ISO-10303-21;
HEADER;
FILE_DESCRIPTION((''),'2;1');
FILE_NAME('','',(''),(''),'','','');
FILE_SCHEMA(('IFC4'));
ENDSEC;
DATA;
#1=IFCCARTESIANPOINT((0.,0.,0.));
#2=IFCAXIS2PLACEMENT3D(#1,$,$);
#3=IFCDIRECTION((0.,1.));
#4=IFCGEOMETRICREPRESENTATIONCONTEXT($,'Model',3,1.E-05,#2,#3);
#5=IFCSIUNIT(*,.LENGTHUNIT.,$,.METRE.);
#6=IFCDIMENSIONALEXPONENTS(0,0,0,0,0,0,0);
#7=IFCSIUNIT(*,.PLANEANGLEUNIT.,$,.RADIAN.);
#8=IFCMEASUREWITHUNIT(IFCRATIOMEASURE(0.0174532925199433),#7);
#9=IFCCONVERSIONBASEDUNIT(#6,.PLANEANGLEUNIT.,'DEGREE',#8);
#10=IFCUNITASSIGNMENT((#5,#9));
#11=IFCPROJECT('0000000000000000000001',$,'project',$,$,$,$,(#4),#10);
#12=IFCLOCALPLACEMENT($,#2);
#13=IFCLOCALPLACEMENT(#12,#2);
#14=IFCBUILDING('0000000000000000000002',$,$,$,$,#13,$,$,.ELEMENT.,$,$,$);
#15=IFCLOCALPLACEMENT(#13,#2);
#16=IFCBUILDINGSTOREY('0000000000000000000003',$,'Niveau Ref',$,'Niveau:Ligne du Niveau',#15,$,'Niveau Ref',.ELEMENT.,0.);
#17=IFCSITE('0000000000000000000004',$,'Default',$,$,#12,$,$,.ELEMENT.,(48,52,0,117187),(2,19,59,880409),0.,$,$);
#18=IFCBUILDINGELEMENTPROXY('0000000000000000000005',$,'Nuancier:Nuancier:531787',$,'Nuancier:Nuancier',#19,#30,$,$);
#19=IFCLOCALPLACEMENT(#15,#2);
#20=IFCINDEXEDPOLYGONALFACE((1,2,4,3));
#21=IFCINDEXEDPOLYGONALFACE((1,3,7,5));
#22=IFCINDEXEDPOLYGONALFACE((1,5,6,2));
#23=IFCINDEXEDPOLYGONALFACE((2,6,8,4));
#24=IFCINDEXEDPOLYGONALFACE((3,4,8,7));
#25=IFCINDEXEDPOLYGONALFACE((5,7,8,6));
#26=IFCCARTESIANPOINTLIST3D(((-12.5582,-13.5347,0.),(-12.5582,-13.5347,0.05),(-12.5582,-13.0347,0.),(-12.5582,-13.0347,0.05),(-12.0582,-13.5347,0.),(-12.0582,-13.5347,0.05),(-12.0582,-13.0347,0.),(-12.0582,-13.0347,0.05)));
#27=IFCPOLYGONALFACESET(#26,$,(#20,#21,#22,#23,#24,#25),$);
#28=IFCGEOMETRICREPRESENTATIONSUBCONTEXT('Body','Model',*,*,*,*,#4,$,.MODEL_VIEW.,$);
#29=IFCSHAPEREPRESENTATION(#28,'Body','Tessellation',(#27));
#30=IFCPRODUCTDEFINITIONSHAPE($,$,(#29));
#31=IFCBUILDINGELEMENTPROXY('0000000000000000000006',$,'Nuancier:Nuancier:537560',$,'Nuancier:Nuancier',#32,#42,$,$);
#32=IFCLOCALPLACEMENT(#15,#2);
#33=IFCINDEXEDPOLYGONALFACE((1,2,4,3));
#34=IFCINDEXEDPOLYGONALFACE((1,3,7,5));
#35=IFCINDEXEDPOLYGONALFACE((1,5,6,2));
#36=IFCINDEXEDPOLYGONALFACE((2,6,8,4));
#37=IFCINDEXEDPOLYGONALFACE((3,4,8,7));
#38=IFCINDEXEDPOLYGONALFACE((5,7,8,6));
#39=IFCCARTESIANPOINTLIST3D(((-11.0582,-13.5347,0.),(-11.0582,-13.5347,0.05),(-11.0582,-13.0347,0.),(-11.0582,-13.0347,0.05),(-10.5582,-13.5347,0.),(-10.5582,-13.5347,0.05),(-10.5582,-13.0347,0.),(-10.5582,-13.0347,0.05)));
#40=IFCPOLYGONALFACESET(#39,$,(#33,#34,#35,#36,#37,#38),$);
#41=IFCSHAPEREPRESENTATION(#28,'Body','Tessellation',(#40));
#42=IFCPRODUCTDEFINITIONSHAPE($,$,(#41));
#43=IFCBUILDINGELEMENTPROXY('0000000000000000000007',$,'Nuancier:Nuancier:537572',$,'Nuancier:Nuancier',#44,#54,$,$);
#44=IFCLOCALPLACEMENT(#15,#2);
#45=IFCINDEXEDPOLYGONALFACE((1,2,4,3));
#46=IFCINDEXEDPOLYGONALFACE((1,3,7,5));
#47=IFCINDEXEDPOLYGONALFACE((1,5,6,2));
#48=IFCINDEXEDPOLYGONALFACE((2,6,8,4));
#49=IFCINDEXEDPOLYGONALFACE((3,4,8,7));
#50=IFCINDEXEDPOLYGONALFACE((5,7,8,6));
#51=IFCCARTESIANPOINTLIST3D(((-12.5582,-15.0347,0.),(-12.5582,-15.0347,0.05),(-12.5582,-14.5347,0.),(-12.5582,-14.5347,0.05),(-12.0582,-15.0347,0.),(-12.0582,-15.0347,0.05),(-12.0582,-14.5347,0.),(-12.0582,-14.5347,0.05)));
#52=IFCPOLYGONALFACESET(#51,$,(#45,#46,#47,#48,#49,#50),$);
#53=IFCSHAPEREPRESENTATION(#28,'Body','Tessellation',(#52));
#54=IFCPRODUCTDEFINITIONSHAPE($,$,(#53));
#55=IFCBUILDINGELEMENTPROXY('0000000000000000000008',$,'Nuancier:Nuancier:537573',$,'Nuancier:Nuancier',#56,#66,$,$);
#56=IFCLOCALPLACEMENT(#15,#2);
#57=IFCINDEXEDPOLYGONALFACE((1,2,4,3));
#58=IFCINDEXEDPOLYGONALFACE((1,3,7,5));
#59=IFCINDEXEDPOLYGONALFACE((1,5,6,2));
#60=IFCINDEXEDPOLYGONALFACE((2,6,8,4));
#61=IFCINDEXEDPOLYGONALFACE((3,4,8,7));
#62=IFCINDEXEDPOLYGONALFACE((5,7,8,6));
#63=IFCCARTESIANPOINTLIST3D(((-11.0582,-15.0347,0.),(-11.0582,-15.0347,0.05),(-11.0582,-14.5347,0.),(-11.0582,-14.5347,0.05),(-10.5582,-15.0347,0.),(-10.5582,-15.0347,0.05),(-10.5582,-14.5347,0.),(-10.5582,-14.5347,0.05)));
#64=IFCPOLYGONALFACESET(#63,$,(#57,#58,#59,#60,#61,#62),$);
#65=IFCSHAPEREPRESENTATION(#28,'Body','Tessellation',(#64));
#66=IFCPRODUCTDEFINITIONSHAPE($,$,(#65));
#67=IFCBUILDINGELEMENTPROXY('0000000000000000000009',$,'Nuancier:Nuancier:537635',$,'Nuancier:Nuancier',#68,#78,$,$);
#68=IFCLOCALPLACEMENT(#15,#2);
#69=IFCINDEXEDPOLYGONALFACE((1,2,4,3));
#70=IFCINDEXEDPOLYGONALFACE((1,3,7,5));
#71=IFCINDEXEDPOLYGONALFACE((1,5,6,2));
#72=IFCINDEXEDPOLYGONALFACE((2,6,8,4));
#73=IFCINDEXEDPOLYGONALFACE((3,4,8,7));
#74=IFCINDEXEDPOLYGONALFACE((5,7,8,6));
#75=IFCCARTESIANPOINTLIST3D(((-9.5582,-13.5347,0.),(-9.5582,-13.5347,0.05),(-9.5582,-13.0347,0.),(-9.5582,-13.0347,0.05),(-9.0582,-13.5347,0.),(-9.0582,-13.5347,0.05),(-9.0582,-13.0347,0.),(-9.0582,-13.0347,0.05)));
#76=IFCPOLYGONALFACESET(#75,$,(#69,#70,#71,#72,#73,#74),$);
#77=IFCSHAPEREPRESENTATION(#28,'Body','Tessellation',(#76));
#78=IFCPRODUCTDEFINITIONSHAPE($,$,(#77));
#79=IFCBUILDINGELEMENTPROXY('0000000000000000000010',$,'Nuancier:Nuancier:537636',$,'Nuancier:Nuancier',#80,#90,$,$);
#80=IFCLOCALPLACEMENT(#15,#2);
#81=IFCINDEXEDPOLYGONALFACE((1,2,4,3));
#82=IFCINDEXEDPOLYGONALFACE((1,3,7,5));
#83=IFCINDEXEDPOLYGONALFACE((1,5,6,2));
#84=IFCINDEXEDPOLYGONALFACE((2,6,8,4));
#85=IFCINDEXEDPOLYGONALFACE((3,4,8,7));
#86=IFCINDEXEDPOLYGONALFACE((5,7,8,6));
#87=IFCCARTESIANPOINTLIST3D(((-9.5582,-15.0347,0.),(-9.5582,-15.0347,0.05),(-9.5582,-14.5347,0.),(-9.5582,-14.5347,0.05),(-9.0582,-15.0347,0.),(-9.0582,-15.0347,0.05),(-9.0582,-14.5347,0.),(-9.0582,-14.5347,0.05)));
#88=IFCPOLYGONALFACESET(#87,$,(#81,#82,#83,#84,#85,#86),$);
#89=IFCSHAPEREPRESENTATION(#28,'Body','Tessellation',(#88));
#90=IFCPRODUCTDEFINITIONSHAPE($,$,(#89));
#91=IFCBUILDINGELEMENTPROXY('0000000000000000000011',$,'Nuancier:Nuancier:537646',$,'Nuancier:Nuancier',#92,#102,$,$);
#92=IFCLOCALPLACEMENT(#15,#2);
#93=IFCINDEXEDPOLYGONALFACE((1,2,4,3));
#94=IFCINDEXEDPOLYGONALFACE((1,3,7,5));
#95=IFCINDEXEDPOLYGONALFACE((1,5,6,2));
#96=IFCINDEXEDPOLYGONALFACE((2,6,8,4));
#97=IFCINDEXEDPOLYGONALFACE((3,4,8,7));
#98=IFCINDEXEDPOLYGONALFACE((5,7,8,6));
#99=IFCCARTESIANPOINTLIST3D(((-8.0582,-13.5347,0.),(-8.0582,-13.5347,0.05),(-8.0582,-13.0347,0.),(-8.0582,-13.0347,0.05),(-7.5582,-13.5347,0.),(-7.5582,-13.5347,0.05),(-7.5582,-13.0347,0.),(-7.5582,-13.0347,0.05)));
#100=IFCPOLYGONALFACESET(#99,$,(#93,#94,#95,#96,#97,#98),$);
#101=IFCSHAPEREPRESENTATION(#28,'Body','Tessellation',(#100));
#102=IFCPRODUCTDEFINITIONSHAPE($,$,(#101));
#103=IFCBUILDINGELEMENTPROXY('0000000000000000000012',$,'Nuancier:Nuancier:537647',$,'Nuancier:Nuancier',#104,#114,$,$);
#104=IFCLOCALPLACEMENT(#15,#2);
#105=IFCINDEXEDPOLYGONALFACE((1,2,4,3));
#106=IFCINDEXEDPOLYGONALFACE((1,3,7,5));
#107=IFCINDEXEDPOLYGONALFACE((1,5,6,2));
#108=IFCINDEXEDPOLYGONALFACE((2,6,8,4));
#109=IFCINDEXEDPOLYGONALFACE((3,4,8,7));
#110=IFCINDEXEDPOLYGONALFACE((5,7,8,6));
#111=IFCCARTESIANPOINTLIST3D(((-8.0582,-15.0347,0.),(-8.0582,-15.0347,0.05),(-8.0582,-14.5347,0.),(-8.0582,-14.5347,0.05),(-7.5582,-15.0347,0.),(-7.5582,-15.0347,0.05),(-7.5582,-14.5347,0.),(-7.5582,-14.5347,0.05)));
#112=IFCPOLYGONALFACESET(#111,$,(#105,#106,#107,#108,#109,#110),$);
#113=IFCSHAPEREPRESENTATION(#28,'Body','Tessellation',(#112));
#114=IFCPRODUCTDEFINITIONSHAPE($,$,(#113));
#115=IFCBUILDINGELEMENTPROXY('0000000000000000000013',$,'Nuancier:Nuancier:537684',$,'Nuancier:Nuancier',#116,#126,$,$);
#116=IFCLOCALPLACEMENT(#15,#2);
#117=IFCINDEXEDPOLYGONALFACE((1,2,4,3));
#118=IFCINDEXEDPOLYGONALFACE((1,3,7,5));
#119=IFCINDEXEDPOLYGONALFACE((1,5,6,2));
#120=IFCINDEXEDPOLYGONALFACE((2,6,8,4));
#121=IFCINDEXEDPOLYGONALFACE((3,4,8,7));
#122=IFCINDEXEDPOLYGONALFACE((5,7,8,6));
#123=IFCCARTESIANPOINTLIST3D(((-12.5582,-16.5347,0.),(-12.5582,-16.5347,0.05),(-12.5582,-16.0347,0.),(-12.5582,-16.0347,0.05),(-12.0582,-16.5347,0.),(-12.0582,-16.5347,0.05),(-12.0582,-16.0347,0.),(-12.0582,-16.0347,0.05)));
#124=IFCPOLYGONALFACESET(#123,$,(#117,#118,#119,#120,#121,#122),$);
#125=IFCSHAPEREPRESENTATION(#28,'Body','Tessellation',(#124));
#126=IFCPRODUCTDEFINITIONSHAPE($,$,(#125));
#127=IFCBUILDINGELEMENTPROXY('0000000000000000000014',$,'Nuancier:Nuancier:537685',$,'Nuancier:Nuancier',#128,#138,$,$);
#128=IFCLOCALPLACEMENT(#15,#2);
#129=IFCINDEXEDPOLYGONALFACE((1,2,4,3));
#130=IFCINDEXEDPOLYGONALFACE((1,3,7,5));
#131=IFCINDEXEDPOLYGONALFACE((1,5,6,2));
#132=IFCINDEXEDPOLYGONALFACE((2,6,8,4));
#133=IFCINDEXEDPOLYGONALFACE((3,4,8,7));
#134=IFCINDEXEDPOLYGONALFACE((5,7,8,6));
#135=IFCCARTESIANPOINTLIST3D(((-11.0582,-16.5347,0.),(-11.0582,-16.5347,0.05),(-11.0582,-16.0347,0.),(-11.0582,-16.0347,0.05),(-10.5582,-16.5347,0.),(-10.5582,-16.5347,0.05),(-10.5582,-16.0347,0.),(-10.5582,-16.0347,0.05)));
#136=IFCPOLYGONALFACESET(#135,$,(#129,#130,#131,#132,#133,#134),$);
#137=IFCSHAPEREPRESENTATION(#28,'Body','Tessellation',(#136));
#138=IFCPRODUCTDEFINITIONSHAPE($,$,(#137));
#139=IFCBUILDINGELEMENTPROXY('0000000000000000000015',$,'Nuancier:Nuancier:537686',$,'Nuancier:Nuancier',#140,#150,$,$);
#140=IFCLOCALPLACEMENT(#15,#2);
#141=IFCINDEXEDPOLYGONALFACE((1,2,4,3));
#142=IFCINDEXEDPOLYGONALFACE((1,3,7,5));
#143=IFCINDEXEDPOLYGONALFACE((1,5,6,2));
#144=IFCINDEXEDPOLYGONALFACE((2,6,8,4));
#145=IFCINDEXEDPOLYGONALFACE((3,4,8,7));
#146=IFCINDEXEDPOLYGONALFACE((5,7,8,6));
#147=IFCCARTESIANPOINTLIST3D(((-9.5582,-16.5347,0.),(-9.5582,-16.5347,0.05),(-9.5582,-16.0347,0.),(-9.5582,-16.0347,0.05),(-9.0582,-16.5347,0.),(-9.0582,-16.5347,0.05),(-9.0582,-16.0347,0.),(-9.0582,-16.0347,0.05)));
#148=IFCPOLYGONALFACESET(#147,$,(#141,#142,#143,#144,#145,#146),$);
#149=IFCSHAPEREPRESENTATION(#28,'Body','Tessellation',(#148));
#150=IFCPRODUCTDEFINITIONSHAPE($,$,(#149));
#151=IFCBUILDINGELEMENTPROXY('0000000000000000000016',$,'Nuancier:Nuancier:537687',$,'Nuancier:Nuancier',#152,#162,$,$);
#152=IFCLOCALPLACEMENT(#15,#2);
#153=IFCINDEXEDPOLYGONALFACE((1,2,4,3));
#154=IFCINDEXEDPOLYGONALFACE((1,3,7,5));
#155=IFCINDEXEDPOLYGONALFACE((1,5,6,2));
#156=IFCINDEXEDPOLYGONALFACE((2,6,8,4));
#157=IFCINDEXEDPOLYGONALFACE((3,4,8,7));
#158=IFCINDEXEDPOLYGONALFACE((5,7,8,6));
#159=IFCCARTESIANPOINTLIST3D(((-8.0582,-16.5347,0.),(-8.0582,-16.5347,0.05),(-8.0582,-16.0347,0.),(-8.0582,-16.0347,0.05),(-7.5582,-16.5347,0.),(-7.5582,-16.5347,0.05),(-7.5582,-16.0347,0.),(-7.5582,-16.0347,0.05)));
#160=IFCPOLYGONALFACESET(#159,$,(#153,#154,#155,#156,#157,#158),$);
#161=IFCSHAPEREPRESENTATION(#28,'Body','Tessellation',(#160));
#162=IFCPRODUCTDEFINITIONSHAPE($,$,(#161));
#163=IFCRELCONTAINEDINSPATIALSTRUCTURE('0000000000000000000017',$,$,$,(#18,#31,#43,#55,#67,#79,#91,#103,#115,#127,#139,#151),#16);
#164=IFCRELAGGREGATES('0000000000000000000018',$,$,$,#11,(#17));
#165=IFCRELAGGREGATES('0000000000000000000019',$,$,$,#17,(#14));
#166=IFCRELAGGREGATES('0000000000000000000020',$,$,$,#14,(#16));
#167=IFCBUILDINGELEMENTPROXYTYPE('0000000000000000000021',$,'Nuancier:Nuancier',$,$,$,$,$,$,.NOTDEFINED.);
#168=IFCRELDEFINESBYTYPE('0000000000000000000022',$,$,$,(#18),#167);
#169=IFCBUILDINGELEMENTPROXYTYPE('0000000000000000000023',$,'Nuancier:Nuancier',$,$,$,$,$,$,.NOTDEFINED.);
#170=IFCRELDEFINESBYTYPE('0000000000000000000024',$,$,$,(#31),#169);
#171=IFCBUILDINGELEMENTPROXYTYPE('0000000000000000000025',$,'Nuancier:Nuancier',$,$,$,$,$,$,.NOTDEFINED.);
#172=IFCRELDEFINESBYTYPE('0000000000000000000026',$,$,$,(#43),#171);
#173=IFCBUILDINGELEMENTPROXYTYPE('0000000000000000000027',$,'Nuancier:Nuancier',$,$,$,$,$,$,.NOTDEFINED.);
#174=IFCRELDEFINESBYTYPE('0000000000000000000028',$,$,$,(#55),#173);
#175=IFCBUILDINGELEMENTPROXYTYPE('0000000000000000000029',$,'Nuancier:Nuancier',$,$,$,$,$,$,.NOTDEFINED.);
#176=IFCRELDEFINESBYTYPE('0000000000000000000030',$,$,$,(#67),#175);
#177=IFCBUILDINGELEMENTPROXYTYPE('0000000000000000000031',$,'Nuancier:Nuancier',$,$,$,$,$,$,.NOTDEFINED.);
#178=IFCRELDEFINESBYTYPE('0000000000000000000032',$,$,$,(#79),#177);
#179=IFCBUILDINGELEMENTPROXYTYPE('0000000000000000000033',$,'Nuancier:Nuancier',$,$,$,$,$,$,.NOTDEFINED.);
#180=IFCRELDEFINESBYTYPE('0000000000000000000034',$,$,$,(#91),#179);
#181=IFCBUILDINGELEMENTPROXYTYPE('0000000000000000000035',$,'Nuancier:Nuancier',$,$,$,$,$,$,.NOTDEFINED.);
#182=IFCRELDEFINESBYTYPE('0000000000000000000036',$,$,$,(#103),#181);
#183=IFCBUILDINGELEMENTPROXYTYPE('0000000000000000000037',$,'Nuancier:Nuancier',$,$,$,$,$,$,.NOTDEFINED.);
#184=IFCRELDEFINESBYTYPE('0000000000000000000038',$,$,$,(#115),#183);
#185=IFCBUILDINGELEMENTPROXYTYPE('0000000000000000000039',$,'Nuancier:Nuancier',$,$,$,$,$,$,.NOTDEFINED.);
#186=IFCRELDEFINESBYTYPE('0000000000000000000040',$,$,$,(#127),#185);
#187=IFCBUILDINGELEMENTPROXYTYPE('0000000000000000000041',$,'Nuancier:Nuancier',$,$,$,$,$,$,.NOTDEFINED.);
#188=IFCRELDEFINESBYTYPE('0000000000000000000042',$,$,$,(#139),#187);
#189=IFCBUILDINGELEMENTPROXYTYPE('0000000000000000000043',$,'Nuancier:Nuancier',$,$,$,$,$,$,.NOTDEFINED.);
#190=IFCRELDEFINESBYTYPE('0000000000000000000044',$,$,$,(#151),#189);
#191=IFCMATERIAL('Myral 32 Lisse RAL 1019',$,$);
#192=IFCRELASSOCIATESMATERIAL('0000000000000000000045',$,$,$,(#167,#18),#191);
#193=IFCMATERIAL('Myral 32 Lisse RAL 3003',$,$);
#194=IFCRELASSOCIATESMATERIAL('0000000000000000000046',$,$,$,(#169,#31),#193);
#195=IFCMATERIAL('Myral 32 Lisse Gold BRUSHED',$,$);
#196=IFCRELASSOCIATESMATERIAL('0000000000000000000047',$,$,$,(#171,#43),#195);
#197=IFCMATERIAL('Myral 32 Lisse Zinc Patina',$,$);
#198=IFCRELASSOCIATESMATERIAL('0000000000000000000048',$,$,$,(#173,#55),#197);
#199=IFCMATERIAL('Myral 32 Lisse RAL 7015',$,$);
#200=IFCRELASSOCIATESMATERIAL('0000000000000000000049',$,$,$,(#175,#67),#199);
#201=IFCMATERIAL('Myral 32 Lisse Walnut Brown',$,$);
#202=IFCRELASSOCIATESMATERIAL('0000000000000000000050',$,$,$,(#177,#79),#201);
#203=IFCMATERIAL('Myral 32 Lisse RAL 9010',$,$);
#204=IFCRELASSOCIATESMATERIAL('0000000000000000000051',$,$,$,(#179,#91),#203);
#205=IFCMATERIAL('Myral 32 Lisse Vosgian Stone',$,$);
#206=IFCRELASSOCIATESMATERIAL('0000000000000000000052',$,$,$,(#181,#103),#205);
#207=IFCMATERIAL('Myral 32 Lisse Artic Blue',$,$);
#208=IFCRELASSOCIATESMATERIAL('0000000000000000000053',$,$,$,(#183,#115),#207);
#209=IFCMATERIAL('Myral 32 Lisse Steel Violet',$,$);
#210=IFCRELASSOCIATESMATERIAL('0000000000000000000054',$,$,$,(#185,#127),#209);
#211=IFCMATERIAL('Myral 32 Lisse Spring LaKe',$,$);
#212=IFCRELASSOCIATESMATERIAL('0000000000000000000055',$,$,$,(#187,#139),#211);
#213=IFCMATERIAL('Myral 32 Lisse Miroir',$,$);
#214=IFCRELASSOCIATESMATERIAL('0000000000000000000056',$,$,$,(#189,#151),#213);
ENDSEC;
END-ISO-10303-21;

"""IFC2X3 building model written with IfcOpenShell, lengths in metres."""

from ifc_helpers import new_model, entity, si_unit, converted_unit, direction, frame, origin, origin_2d_with_axis, place, context, subcontext, project, spatial, rectangle, extrude, source, transform, mapped, material, type_object, type_shapes, element, save


model = new_model("IFC2X3")

# Units and contexts
model_context = context("Model", 3, precision=1e-05, world=origin(), true_north=direction((0.0, 1.0)))
body_context = subcontext(model_context, "Body", "Model", "MODEL_VIEW")
ifc_project = project(units=[si_unit("LENGTHUNIT", "METRE"), converted_unit("PLANEANGLEUNIT", "DEGREE", entity("IfcRatioMeasure", 0.0174532925199433), si_unit("PLANEANGLEUNIT", "RADIAN"), dimensions=[0, 0, 0, 0, 0, 0, 0])], contexts=[model_context])

# Site, building, storey
site_placement = place(None, origin())
site = spatial("IfcSite", under=ifc_project, at=site_placement, Name="Default", CompositionType="ELEMENT", RefLatitude=(48, 52, 0, 117187), RefLongitude=(2, 19, 59, 880409), RefElevation=0.0)
building_placement = place(site_placement, origin())
building = spatial("IfcBuilding", under=site, at=building_placement, CompositionType="ELEMENT")
storey_placement = place(building_placement, origin())
storey = spatial("IfcBuildingStorey", under=building, at=storey_placement, Name="Niveau Ref", ObjectType="Niveau:Ligne du Niveau", LongName="Niveau Ref", CompositionType="ELEMENT", Elevation=0.0)

# Shared definitions
ifc_material_1 = material(Name="Myral 32 Lisse RAL 7015")

# Building element proxies
ifc_material_2 = material(Name="Myral 32 Lisse RAL 1019")
building_element_proxy_type_1 = type_object("IfcBuildingElementProxyType", Name="Nuancier:Nuancier", PredefinedType="NOTDEFINED", material=ifc_material_2)
shared_shape_1 = source(origin(), body_context, "Body", "SweptSolid", [
    extrude(rectangle(XDim=0.5, YDim=0.5, at=origin_2d_with_axis()), frame((0.0, 0.0, 0.0), z_axis=(0.0, 0.0, 1.0), x_axis=(-1.0, 0.0, 0.0)), (0.0, 0.0, 1.0), 0.05),
])
type_shapes(building_element_proxy_type_1, [shared_shape_1])
proxy_1_placement = place(storey_placement, frame((-12.3082, -13.2847, 0.0)))
element("IfcBuildingElementProxy", 1, at=proxy_1_placement, inside=storey, type_object=building_element_proxy_type_1, material=ifc_material_2, Name="Nuancier:Nuancier:531787", ObjectType="Nuancier:Nuancier", context=body_context, shape_type="MappedRepresentation", body=[
    mapped(shared_shape_1, transform((0.0, 0.0, 0.0), scale=1.0)),
])
ifc_material_3 = material(Name="Myral 32 Lisse RAL 3003")
building_element_proxy_type_2 = type_object("IfcBuildingElementProxyType", Name="Nuancier:Nuancier", PredefinedType="NOTDEFINED", material=ifc_material_3)
shared_shape_2 = source(origin(), body_context, "Body", "SweptSolid", [
    extrude(rectangle(XDim=0.5, YDim=0.5, at=origin_2d_with_axis()), frame((0.0, 0.0, 0.0), z_axis=(0.0, 0.0, 1.0), x_axis=(-1.0, 0.0, 0.0)), (0.0, 0.0, 1.0), 0.05),
])
type_shapes(building_element_proxy_type_2, [shared_shape_2])
proxy_2_placement = place(storey_placement, frame((-10.8082, -13.2847, 0.0)))
element("IfcBuildingElementProxy", 2, at=proxy_2_placement, inside=storey, type_object=building_element_proxy_type_2, material=ifc_material_3, Name="Nuancier:Nuancier:537560", ObjectType="Nuancier:Nuancier", context=body_context, shape_type="MappedRepresentation", body=[
    mapped(shared_shape_2, transform((0.0, 0.0, 0.0), scale=1.0)),
])
ifc_material_4 = material(Name="Myral 32 Lisse Gold BRUSHED")
building_element_proxy_type_3 = type_object("IfcBuildingElementProxyType", Name="Nuancier:Nuancier", PredefinedType="NOTDEFINED", material=ifc_material_4)
shared_shape_3 = source(origin(), body_context, "Body", "SweptSolid", [
    extrude(rectangle(XDim=0.5, YDim=0.5, at=origin_2d_with_axis()), frame((0.0, 0.0, 0.0), z_axis=(0.0, 0.0, 1.0), x_axis=(-1.0, 0.0, 0.0)), (0.0, 0.0, 1.0), 0.05),
])
type_shapes(building_element_proxy_type_3, [shared_shape_3])
proxy_3_placement = place(storey_placement, frame((-12.3082, -14.7847, 0.0)))
element("IfcBuildingElementProxy", 3, at=proxy_3_placement, inside=storey, type_object=building_element_proxy_type_3, material=ifc_material_4, Name="Nuancier:Nuancier:537572", ObjectType="Nuancier:Nuancier", context=body_context, shape_type="MappedRepresentation", body=[
    mapped(shared_shape_3, transform((0.0, 0.0, 0.0), scale=1.0)),
])
ifc_material_5 = material(Name="Myral 32 Lisse Zinc Patina")
building_element_proxy_type_4 = type_object("IfcBuildingElementProxyType", Name="Nuancier:Nuancier", PredefinedType="NOTDEFINED", material=ifc_material_5)
shared_shape_4 = source(origin(), body_context, "Body", "SweptSolid", [
    extrude(rectangle(XDim=0.5, YDim=0.5, at=origin_2d_with_axis()), frame((0.0, 0.0, 0.0), z_axis=(0.0, 0.0, 1.0), x_axis=(-1.0, 0.0, 0.0)), (0.0, 0.0, 1.0), 0.05),
])
type_shapes(building_element_proxy_type_4, [shared_shape_4])
proxy_4_placement = place(storey_placement, frame((-10.8082, -14.7847, 0.0)))
element("IfcBuildingElementProxy", 4, at=proxy_4_placement, inside=storey, type_object=building_element_proxy_type_4, material=ifc_material_5, Name="Nuancier:Nuancier:537573", ObjectType="Nuancier:Nuancier", context=body_context, shape_type="MappedRepresentation", body=[
    mapped(shared_shape_4, transform((0.0, 0.0, 0.0), scale=1.0)),
])
building_element_proxy_type_5 = type_object("IfcBuildingElementProxyType", Name="Nuancier:Nuancier", PredefinedType="NOTDEFINED", material=ifc_material_1)
shared_shape_5 = source(origin(), body_context, "Body", "SweptSolid", [
    extrude(rectangle(XDim=0.5, YDim=0.5, at=origin_2d_with_axis()), frame((0.0, 0.0, 0.0), z_axis=(0.0, 0.0, 1.0), x_axis=(-1.0, 0.0, 0.0)), (0.0, 0.0, 1.0), 0.05),
])
type_shapes(building_element_proxy_type_5, [shared_shape_5])
proxy_5_placement = place(storey_placement, frame((-9.3082, -13.2847, 0.0)))
element("IfcBuildingElementProxy", 5, at=proxy_5_placement, inside=storey, type_object=building_element_proxy_type_5, material=ifc_material_1, Name="Nuancier:Nuancier:537635", ObjectType="Nuancier:Nuancier", context=body_context, shape_type="MappedRepresentation", body=[
    mapped(shared_shape_5, transform((0.0, 0.0, 0.0), scale=1.0)),
])
ifc_material_6 = material(Name="Myral 32 Lisse Walnut Brown")
building_element_proxy_type_6 = type_object("IfcBuildingElementProxyType", Name="Nuancier:Nuancier", PredefinedType="NOTDEFINED", material=ifc_material_6)
shared_shape_6 = source(origin(), body_context, "Body", "SweptSolid", [
    extrude(rectangle(XDim=0.5, YDim=0.5, at=origin_2d_with_axis()), frame((0.0, 0.0, 0.0), z_axis=(0.0, 0.0, 1.0), x_axis=(-1.0, 0.0, 0.0)), (0.0, 0.0, 1.0), 0.05),
])
type_shapes(building_element_proxy_type_6, [shared_shape_6])
proxy_6_placement = place(storey_placement, frame((-9.3082, -14.7847, 0.0)))
element("IfcBuildingElementProxy", 6, at=proxy_6_placement, inside=storey, type_object=building_element_proxy_type_6, material=ifc_material_6, Name="Nuancier:Nuancier:537636", ObjectType="Nuancier:Nuancier", context=body_context, shape_type="MappedRepresentation", body=[
    mapped(shared_shape_6, transform((0.0, 0.0, 0.0), scale=1.0)),
])
ifc_material_7 = material(Name="Myral 32 Lisse RAL 9010")
building_element_proxy_type_7 = type_object("IfcBuildingElementProxyType", Name="Nuancier:Nuancier", PredefinedType="NOTDEFINED", material=ifc_material_7)
shared_shape_7 = source(origin(), body_context, "Body", "SweptSolid", [
    extrude(rectangle(XDim=0.5, YDim=0.5, at=origin_2d_with_axis()), frame((0.0, 0.0, 0.0), z_axis=(0.0, 0.0, 1.0), x_axis=(-1.0, 0.0, 0.0)), (0.0, 0.0, 1.0), 0.05),
])
type_shapes(building_element_proxy_type_7, [shared_shape_7])
proxy_7_placement = place(storey_placement, frame((-7.8082, -13.2847, 0.0)))
element("IfcBuildingElementProxy", 7, at=proxy_7_placement, inside=storey, type_object=building_element_proxy_type_7, material=ifc_material_7, Name="Nuancier:Nuancier:537646", ObjectType="Nuancier:Nuancier", context=body_context, shape_type="MappedRepresentation", body=[
    mapped(shared_shape_7, transform((0.0, 0.0, 0.0), scale=1.0)),
])
ifc_material_8 = material(Name="Myral 32 Lisse Vosgian Stone")
building_element_proxy_type_8 = type_object("IfcBuildingElementProxyType", Name="Nuancier:Nuancier", PredefinedType="NOTDEFINED", material=ifc_material_8)
shared_shape_8 = source(origin(), body_context, "Body", "SweptSolid", [
    extrude(rectangle(XDim=0.5, YDim=0.5, at=origin_2d_with_axis()), frame((0.0, 0.0, 0.0), z_axis=(0.0, 0.0, 1.0), x_axis=(-1.0, 0.0, 0.0)), (0.0, 0.0, 1.0), 0.05),
])
type_shapes(building_element_proxy_type_8, [shared_shape_8])
proxy_8_placement = place(storey_placement, frame((-7.8082, -14.7847, 0.0)))
element("IfcBuildingElementProxy", 8, at=proxy_8_placement, inside=storey, type_object=building_element_proxy_type_8, material=ifc_material_8, Name="Nuancier:Nuancier:537647", ObjectType="Nuancier:Nuancier", context=body_context, shape_type="MappedRepresentation", body=[
    mapped(shared_shape_8, transform((0.0, 0.0, 0.0), scale=1.0)),
])
ifc_material_9 = material(Name="Myral 32 Lisse Artic Blue")
building_element_proxy_type_9 = type_object("IfcBuildingElementProxyType", Name="Nuancier:Nuancier", PredefinedType="NOTDEFINED", material=ifc_material_9)
shared_shape_9 = source(origin(), body_context, "Body", "SweptSolid", [
    extrude(rectangle(XDim=0.5, YDim=0.5, at=origin_2d_with_axis()), frame((0.0, 0.0, 0.0), z_axis=(0.0, 0.0, 1.0), x_axis=(-1.0, 0.0, 0.0)), (0.0, 0.0, 1.0), 0.05),
])
type_shapes(building_element_proxy_type_9, [shared_shape_9])
proxy_9_placement = place(storey_placement, frame((-12.3082, -16.2847, 0.0)))
element("IfcBuildingElementProxy", 9, at=proxy_9_placement, inside=storey, type_object=building_element_proxy_type_9, material=ifc_material_9, Name="Nuancier:Nuancier:537684", ObjectType="Nuancier:Nuancier", context=body_context, shape_type="MappedRepresentation", body=[
    mapped(shared_shape_9, transform((0.0, 0.0, 0.0), scale=1.0)),
])
ifc_material_10 = material(Name="Myral 32 Lisse Steel Violet")
building_element_proxy_type_10 = type_object("IfcBuildingElementProxyType", Name="Nuancier:Nuancier", PredefinedType="NOTDEFINED", material=ifc_material_10)
shared_shape_10 = source(origin(), body_context, "Body", "SweptSolid", [
    extrude(rectangle(XDim=0.5, YDim=0.5, at=origin_2d_with_axis()), frame((0.0, 0.0, 0.0), z_axis=(0.0, 0.0, 1.0), x_axis=(-1.0, 0.0, 0.0)), (0.0, 0.0, 1.0), 0.05),
])
type_shapes(building_element_proxy_type_10, [shared_shape_10])
proxy_10_placement = place(storey_placement, frame((-10.8082, -16.2847, 0.0)))
element("IfcBuildingElementProxy", 10, at=proxy_10_placement, inside=storey, type_object=building_element_proxy_type_10, material=ifc_material_10, Name="Nuancier:Nuancier:537685", ObjectType="Nuancier:Nuancier", context=body_context, shape_type="MappedRepresentation", body=[
    mapped(shared_shape_10, transform((0.0, 0.0, 0.0), scale=1.0)),
])
ifc_material_11 = material(Name="Myral 32 Lisse Spring LaKe")
building_element_proxy_type_11 = type_object("IfcBuildingElementProxyType", Name="Nuancier:Nuancier", PredefinedType="NOTDEFINED", material=ifc_material_11)
shared_shape_11 = source(origin(), body_context, "Body", "SweptSolid", [
    extrude(rectangle(XDim=0.5, YDim=0.5, at=origin_2d_with_axis()), frame((0.0, 0.0, 0.0), z_axis=(0.0, 0.0, 1.0), x_axis=(-1.0, 0.0, 0.0)), (0.0, 0.0, 1.0), 0.05),
])
type_shapes(building_element_proxy_type_11, [shared_shape_11])
proxy_11_placement = place(storey_placement, frame((-9.3082, -16.2847, 0.0)))
element("IfcBuildingElementProxy", 11, at=proxy_11_placement, inside=storey, type_object=building_element_proxy_type_11, material=ifc_material_11, Name="Nuancier:Nuancier:537686", ObjectType="Nuancier:Nuancier", context=body_context, shape_type="MappedRepresentation", body=[
    mapped(shared_shape_11, transform((0.0, 0.0, 0.0), scale=1.0)),
])
ifc_material_12 = material(Name="Myral 32 Lisse Miroir")
building_element_proxy_type_12 = type_object("IfcBuildingElementProxyType", Name="Nuancier:Nuancier", PredefinedType="NOTDEFINED", material=ifc_material_12)
shared_shape_12 = source(origin(), body_context, "Body", "SweptSolid", [
    extrude(rectangle(XDim=0.5, YDim=0.5, at=origin_2d_with_axis()), frame((0.0, 0.0, 0.0), z_axis=(0.0, 0.0, 1.0), x_axis=(-1.0, 0.0, 0.0)), (0.0, 0.0, 1.0), 0.05),
])
type_shapes(building_element_proxy_type_12, [shared_shape_12])
proxy_12_placement = place(storey_placement, frame((-7.8082, -16.2847, 0.0)))
element("IfcBuildingElementProxy", 12, at=proxy_12_placement, inside=storey, type_object=building_element_proxy_type_12, material=ifc_material_12, Name="Nuancier:Nuancier:537687", ObjectType="Nuancier:Nuancier", context=body_context, shape_type="MappedRepresentation", body=[
    mapped(shared_shape_12, transform((0.0, 0.0, 0.0), scale=1.0)),
])

save(model, "model.ifc")
